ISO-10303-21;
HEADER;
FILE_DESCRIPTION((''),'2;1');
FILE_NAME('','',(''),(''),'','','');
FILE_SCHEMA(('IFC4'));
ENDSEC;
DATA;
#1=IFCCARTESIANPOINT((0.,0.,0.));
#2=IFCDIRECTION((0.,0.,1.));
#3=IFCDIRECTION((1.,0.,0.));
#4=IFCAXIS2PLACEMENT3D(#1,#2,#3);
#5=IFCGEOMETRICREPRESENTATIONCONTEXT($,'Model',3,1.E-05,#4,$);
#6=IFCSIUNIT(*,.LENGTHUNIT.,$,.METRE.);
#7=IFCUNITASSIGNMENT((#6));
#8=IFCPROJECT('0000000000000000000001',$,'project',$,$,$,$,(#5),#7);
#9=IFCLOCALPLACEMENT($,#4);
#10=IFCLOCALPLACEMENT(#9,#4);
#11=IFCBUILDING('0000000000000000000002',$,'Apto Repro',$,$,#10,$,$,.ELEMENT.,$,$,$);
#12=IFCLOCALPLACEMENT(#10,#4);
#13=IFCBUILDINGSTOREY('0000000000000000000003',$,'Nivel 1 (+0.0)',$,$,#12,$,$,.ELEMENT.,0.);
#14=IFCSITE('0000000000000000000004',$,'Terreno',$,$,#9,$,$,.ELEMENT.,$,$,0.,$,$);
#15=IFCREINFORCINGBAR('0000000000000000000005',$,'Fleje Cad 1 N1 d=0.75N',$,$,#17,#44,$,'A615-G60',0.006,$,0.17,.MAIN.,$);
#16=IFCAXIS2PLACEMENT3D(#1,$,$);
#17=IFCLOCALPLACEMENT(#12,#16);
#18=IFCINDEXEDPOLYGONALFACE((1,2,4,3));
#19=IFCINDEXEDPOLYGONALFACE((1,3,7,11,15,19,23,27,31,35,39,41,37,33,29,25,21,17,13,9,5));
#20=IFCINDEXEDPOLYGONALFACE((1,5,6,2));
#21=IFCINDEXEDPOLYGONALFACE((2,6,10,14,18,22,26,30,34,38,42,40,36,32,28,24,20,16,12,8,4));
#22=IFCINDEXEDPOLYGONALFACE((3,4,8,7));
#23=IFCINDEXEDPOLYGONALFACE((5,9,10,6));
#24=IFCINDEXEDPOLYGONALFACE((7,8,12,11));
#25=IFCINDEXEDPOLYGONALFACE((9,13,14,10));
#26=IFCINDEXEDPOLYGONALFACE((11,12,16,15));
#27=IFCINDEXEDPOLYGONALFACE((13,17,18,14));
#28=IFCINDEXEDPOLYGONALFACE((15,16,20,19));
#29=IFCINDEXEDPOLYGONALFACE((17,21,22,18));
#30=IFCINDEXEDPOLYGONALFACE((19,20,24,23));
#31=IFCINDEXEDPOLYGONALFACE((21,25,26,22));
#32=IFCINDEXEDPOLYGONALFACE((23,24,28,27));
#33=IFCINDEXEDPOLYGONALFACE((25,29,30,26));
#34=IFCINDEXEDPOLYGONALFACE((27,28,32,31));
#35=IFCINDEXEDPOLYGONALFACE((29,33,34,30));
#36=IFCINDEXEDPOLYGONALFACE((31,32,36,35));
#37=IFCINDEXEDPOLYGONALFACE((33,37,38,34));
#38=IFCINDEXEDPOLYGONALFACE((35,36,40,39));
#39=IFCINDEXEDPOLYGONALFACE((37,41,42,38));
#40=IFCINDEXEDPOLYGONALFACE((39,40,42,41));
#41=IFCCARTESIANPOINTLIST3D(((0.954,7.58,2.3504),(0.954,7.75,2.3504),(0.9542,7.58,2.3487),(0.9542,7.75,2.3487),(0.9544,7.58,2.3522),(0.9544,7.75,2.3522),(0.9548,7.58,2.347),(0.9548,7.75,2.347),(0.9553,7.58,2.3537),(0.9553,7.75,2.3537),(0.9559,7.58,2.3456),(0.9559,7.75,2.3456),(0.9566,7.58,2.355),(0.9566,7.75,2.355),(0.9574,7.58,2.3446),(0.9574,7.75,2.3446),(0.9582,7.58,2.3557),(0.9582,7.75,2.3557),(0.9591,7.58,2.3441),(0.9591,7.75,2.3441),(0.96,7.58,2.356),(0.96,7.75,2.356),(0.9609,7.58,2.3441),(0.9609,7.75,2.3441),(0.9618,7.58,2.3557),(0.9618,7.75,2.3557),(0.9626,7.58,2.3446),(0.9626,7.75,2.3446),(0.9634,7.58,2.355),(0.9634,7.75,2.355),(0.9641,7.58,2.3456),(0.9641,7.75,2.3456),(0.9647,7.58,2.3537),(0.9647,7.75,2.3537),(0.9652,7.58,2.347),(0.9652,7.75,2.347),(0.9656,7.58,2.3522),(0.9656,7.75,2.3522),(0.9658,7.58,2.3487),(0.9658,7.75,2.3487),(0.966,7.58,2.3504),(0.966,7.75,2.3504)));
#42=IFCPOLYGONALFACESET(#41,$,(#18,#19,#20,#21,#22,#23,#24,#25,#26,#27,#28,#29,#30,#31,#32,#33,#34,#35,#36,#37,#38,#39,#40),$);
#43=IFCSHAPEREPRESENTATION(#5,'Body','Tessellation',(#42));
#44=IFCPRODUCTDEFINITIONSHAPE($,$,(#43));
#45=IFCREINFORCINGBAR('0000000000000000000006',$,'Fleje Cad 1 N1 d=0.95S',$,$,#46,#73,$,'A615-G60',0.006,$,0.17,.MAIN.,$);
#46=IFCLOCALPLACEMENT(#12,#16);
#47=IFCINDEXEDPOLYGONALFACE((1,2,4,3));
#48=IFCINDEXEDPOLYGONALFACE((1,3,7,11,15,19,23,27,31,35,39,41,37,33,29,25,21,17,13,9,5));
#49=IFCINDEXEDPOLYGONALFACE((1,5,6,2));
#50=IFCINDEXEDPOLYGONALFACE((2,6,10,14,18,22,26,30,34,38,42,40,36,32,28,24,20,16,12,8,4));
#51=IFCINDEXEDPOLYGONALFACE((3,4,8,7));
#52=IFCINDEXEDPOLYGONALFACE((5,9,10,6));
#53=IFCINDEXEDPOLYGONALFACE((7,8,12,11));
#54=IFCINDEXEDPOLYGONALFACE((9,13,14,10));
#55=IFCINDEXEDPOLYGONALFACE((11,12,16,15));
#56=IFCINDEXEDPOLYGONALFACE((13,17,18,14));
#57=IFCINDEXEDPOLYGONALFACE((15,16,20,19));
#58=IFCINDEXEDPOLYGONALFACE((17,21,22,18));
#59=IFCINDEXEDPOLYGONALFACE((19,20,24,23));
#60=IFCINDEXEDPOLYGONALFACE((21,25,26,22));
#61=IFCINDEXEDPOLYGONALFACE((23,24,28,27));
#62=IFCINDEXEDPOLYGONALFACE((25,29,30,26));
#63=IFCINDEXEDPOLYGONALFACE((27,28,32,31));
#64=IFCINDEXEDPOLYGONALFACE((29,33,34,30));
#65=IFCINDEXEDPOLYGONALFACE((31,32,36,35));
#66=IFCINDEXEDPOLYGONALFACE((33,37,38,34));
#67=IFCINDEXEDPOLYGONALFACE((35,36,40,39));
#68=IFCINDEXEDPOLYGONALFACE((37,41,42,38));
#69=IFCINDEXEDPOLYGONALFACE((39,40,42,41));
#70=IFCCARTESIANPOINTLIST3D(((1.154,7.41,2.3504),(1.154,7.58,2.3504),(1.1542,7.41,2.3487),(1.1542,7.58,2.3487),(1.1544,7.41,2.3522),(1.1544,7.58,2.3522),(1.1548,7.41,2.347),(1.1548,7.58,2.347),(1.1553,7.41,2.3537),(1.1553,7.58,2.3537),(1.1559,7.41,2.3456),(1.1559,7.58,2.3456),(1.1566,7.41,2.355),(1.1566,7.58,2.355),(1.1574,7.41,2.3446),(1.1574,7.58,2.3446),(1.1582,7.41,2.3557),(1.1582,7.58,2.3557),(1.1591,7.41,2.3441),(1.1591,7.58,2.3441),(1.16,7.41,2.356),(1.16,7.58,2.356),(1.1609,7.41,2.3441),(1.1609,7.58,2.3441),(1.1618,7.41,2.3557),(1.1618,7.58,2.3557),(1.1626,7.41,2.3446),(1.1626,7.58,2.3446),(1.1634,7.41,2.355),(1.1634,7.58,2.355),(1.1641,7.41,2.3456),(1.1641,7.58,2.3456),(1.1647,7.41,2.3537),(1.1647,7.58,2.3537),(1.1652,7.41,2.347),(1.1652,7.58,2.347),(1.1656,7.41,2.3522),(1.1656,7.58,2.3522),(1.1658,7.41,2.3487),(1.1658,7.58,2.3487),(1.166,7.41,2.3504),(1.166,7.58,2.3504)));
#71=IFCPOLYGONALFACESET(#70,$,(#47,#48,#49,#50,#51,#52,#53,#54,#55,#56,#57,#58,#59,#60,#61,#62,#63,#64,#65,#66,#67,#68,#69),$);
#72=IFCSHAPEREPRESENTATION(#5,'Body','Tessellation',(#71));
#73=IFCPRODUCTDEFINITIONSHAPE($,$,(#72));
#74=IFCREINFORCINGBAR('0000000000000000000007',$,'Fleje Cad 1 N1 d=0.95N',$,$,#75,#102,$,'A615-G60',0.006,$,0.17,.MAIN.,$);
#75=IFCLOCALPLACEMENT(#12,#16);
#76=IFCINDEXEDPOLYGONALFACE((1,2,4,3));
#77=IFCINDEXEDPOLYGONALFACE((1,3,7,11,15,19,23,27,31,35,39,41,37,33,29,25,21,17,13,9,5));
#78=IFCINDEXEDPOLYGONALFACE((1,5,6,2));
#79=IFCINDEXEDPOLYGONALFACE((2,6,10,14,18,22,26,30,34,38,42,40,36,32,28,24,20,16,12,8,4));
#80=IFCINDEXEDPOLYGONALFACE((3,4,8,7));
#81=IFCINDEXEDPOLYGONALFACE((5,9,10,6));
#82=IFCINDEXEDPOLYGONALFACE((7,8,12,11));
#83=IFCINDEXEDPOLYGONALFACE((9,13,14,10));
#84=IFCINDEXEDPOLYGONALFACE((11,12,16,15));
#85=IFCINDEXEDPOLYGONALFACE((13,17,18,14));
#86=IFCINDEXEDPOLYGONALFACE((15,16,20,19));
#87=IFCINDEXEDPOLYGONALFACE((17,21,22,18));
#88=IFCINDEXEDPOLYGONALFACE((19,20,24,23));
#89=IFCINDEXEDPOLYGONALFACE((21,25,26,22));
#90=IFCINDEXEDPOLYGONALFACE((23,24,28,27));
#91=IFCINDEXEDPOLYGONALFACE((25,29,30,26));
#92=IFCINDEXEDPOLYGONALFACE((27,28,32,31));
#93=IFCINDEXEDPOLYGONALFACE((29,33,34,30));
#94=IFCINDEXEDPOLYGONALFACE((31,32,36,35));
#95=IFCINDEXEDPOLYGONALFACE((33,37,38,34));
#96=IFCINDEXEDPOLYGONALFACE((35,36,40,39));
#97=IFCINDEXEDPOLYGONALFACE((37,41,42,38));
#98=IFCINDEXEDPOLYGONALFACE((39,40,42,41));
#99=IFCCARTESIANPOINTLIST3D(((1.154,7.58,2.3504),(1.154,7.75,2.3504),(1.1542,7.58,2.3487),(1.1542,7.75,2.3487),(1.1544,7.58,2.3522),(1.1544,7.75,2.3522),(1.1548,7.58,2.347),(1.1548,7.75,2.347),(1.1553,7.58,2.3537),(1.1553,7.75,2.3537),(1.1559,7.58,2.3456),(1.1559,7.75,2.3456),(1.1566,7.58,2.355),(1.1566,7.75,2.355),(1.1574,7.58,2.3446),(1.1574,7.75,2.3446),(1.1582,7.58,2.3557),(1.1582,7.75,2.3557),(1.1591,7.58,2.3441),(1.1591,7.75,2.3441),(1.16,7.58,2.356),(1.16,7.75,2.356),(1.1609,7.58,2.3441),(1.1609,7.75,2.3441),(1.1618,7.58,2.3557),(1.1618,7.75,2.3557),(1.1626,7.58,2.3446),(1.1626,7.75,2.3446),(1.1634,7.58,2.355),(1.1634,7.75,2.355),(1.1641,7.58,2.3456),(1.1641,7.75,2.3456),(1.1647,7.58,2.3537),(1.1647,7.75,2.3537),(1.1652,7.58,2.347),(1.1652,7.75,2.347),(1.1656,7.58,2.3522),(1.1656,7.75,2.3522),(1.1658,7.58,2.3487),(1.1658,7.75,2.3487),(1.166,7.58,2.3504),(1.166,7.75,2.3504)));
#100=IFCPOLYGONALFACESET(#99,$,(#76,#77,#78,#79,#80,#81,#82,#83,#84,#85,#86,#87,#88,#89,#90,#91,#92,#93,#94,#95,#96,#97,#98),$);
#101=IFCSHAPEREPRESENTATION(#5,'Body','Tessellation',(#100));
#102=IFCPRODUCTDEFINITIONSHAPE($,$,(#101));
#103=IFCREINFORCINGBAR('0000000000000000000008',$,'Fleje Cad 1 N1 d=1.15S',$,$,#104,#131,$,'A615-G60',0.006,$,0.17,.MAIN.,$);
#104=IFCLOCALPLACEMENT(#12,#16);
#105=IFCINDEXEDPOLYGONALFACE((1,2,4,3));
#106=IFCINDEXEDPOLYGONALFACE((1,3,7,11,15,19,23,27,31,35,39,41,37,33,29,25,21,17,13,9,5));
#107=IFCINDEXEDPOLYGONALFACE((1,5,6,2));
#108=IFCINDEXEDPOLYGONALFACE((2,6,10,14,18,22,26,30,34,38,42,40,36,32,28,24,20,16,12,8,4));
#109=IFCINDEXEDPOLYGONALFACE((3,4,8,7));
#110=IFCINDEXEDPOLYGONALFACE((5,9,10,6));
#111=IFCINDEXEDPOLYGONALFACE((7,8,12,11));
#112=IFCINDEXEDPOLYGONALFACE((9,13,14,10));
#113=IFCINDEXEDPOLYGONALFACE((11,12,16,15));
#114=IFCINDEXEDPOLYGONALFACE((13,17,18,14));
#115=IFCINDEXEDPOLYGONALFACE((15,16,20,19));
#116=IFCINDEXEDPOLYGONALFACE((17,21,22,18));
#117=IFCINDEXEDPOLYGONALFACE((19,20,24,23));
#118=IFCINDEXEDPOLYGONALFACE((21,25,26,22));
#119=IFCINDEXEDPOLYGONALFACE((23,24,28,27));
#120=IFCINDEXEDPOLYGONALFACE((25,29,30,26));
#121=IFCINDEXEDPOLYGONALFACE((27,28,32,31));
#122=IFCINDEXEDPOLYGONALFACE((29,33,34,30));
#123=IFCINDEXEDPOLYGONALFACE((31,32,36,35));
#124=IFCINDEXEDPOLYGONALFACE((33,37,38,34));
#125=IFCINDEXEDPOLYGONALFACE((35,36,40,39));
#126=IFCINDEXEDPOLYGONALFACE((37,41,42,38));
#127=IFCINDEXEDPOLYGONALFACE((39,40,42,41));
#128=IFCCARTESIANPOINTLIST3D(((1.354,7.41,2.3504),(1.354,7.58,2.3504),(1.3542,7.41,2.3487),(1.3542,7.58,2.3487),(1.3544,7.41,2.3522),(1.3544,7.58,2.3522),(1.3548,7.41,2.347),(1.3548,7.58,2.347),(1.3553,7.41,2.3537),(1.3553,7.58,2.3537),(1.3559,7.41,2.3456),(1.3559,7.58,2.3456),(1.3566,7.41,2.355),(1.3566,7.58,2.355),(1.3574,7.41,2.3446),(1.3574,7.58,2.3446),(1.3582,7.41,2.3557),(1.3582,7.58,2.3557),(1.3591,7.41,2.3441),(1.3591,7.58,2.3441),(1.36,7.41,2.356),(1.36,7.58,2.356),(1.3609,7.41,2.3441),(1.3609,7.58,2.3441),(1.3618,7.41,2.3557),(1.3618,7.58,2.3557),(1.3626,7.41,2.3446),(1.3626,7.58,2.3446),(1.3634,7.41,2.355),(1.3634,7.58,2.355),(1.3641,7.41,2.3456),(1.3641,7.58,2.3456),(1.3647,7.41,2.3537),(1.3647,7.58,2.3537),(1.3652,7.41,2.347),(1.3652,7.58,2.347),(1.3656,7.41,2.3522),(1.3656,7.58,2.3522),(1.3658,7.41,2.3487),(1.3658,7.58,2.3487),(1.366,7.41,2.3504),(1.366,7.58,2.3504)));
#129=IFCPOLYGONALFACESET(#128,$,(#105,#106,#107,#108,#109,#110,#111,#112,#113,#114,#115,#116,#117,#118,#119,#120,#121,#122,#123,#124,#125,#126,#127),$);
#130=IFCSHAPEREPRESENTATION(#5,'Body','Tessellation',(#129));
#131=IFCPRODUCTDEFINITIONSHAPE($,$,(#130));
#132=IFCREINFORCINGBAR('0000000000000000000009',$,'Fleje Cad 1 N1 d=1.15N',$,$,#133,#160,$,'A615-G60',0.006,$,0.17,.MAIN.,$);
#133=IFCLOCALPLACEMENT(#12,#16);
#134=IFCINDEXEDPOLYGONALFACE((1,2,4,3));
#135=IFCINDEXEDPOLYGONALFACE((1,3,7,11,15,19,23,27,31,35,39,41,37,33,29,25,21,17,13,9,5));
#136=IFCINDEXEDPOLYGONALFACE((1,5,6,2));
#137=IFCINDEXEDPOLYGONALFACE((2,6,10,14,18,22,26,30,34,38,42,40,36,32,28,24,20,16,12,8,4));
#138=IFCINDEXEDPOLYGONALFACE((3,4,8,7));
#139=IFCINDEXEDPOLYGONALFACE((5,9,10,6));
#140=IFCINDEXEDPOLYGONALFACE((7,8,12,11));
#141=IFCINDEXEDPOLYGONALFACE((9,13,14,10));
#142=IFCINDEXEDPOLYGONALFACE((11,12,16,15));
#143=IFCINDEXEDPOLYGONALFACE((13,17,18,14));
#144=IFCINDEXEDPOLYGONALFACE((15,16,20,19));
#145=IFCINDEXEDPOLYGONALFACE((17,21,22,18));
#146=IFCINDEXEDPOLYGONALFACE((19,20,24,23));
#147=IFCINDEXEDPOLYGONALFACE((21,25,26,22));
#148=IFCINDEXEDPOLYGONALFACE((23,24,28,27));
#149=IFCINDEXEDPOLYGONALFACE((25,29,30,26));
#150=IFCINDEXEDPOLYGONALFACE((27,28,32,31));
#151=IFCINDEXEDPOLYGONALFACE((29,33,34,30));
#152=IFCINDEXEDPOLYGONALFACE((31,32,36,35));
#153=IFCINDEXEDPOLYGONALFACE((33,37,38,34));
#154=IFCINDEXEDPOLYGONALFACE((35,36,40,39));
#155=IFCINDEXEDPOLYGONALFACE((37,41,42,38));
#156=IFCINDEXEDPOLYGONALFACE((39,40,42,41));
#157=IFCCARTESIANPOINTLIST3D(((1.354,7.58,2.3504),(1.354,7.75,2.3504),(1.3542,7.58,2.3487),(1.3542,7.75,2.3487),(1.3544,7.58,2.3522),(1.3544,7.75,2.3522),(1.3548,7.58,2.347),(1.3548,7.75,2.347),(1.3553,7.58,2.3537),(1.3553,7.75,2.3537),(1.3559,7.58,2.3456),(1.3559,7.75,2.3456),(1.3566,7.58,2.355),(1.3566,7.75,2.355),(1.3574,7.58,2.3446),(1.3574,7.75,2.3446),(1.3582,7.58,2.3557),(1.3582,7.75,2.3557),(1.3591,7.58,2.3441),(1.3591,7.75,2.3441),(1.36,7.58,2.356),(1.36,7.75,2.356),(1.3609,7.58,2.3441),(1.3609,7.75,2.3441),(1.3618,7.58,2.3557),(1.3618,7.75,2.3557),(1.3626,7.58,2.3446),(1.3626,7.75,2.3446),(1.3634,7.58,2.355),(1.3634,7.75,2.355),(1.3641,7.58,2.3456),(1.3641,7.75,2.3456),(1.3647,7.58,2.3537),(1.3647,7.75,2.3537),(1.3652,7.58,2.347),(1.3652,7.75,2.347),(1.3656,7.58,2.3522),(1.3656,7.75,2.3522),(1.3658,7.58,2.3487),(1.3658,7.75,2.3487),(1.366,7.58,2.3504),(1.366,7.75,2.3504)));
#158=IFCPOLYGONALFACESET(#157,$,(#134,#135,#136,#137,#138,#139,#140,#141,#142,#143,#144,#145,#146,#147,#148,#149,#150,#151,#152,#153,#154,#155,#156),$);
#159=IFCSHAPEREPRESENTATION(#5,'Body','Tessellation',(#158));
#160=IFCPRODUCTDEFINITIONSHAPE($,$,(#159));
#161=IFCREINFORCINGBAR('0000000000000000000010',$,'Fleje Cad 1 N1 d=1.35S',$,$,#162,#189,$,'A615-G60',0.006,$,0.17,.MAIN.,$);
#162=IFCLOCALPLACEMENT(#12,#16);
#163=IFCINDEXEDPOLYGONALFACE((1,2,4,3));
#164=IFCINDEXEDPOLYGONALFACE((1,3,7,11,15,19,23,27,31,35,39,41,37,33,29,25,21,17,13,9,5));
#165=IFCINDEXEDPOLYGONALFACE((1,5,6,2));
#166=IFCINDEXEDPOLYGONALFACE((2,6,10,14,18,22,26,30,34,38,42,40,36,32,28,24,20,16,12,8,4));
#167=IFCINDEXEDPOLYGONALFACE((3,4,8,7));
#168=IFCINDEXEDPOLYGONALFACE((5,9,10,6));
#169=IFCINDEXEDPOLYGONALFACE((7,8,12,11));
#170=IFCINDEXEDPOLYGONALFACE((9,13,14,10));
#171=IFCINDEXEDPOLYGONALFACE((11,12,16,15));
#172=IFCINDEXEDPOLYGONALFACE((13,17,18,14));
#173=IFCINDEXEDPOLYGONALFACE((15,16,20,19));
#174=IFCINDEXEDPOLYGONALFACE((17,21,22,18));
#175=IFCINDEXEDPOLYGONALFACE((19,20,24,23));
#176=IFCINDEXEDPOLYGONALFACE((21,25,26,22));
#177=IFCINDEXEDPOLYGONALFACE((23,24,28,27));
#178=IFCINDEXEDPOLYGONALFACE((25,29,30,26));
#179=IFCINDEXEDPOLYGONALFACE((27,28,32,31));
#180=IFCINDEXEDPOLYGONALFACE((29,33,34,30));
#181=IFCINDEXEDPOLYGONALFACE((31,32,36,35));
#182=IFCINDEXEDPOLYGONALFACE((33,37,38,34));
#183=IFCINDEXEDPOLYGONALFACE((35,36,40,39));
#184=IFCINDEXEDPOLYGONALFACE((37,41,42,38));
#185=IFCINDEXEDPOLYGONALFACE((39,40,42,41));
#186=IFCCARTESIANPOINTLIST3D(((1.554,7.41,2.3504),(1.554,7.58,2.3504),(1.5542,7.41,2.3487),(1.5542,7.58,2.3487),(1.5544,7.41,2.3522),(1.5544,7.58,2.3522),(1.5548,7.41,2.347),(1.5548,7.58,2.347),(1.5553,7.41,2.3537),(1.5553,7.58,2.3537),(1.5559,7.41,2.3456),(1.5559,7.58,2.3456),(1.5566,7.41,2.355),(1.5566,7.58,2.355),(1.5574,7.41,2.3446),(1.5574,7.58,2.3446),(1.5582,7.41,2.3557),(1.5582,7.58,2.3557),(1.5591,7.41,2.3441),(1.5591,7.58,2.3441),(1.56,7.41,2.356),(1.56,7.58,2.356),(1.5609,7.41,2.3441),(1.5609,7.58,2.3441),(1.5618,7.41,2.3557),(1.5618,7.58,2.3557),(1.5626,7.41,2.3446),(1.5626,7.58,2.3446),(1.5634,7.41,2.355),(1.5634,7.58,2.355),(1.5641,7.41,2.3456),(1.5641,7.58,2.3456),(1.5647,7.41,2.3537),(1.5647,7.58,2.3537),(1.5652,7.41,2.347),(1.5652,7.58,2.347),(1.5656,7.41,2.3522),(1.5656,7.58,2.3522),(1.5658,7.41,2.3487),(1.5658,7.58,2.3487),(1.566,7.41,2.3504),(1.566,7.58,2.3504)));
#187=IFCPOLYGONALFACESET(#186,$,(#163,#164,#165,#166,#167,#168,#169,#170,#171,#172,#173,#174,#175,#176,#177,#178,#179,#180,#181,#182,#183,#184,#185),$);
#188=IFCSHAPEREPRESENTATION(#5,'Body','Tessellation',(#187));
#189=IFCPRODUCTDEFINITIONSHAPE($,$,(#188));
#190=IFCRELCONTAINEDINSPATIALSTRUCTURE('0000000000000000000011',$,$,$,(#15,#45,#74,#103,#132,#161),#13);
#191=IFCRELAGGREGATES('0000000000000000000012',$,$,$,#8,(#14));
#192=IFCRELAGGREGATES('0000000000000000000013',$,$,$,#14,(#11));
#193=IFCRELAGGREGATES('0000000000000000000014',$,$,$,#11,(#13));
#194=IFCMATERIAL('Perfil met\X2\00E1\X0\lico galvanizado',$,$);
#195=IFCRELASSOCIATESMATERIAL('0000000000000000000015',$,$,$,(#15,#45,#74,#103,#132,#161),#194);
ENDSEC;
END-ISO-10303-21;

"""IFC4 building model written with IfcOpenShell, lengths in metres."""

from ifc_helpers import new_model, si_unit, frame, origin_with_axes, origin_2d_with_axis, place, context, project, spatial, circle, extrude, material, element, save


model = new_model("IFC4")

# Units and contexts
model_context = context("Model", 3, precision=1e-05, world=origin_with_axes())
ifc_project = project(units=[si_unit("LENGTHUNIT", "METRE")], contexts=[model_context])

# Site, building, storey
site_placement = place(None, origin_with_axes())
site = spatial("IfcSite", under=ifc_project, at=site_placement, Name="Terreno", CompositionType="ELEMENT", RefElevation=0.0)
building_placement = place(site_placement, origin_with_axes())
building = spatial("IfcBuilding", under=site, at=building_placement, Name="Apto Repro", CompositionType="ELEMENT")
storey_placement = place(building_placement, origin_with_axes())
storey = spatial("IfcBuildingStorey", under=building, at=storey_placement, Name="Nivel 1 (+0.0)", CompositionType="ELEMENT", Elevation=0.0)

# Reinforcing bars
ifc_material = material(Name="Perfil metálico galvanizado")
reinforcing_bar_1_placement = place(storey_placement, origin_with_axes())
element("IfcReinforcingBar", 1, at=reinforcing_bar_1_placement, inside=storey, material=ifc_material, Name="Fleje Cad 1 N1 d=0.75N", SteelGrade="A615-G60", BarLength=0.17, NominalDiameter=0.006, PredefinedType="MAIN", context=model_context, shape_type="SweptSolid", body=[
    extrude(circle(Radius=0.006, at=origin_2d_with_axis()), frame((0.96, 7.58, 2.35), z_axis=(0.0, 1.0, 0.0), x_axis=(0.0, 0.0, 1.0)), (0.0, 0.0, 1.0), 0.17),
])
reinforcing_bar_2_placement = place(storey_placement, origin_with_axes())
element("IfcReinforcingBar", 2, at=reinforcing_bar_2_placement, inside=storey, material=ifc_material, Name="Fleje Cad 1 N1 d=0.95S", SteelGrade="A615-G60", BarLength=0.17, NominalDiameter=0.006, PredefinedType="MAIN", context=model_context, shape_type="SweptSolid", body=[
    extrude(circle(Radius=0.006, at=origin_2d_with_axis()), frame((1.16, 7.41, 2.35), z_axis=(0.0, 1.0, 0.0), x_axis=(0.0, 0.0, 1.0)), (0.0, 0.0, 1.0), 0.17),
])
reinforcing_bar_3_placement = place(storey_placement, origin_with_axes())
element("IfcReinforcingBar", 3, at=reinforcing_bar_3_placement, inside=storey, material=ifc_material, Name="Fleje Cad 1 N1 d=0.95N", SteelGrade="A615-G60", BarLength=0.17, NominalDiameter=0.006, PredefinedType="MAIN", context=model_context, shape_type="SweptSolid", body=[
    extrude(circle(Radius=0.006, at=origin_2d_with_axis()), frame((1.16, 7.58, 2.35), z_axis=(0.0, 1.0, 0.0), x_axis=(0.0, 0.0, 1.0)), (0.0, 0.0, 1.0), 0.17),
])
reinforcing_bar_4_placement = place(storey_placement, origin_with_axes())
element("IfcReinforcingBar", 4, at=reinforcing_bar_4_placement, inside=storey, material=ifc_material, Name="Fleje Cad 1 N1 d=1.15S", SteelGrade="A615-G60", BarLength=0.17, NominalDiameter=0.006, PredefinedType="MAIN", context=model_context, shape_type="SweptSolid", body=[
    extrude(circle(Radius=0.006, at=origin_2d_with_axis()), frame((1.36, 7.41, 2.35), z_axis=(0.0, 1.0, 0.0), x_axis=(0.0, 0.0, 1.0)), (0.0, 0.0, 1.0), 0.17),
])
reinforcing_bar_5_placement = place(storey_placement, origin_with_axes())
element("IfcReinforcingBar", 5, at=reinforcing_bar_5_placement, inside=storey, material=ifc_material, Name="Fleje Cad 1 N1 d=1.15N", SteelGrade="A615-G60", BarLength=0.17, NominalDiameter=0.006, PredefinedType="MAIN", context=model_context, shape_type="SweptSolid", body=[
    extrude(circle(Radius=0.006, at=origin_2d_with_axis()), frame((1.36, 7.58, 2.35), z_axis=(0.0, 1.0, 0.0), x_axis=(0.0, 0.0, 1.0)), (0.0, 0.0, 1.0), 0.17),
])
reinforcing_bar_6_placement = place(storey_placement, origin_with_axes())
element("IfcReinforcingBar", 6, at=reinforcing_bar_6_placement, inside=storey, material=ifc_material, Name="Fleje Cad 1 N1 d=1.35S", SteelGrade="A615-G60", BarLength=0.17, NominalDiameter=0.006, PredefinedType="MAIN", context=model_context, shape_type="SweptSolid", body=[
    extrude(circle(Radius=0.006, at=origin_2d_with_axis()), frame((1.56, 7.41, 2.35), z_axis=(0.0, 1.0, 0.0), x_axis=(0.0, 0.0, 1.0)), (0.0, 0.0, 1.0), 0.17),
])

save(model, "model.ifc")
